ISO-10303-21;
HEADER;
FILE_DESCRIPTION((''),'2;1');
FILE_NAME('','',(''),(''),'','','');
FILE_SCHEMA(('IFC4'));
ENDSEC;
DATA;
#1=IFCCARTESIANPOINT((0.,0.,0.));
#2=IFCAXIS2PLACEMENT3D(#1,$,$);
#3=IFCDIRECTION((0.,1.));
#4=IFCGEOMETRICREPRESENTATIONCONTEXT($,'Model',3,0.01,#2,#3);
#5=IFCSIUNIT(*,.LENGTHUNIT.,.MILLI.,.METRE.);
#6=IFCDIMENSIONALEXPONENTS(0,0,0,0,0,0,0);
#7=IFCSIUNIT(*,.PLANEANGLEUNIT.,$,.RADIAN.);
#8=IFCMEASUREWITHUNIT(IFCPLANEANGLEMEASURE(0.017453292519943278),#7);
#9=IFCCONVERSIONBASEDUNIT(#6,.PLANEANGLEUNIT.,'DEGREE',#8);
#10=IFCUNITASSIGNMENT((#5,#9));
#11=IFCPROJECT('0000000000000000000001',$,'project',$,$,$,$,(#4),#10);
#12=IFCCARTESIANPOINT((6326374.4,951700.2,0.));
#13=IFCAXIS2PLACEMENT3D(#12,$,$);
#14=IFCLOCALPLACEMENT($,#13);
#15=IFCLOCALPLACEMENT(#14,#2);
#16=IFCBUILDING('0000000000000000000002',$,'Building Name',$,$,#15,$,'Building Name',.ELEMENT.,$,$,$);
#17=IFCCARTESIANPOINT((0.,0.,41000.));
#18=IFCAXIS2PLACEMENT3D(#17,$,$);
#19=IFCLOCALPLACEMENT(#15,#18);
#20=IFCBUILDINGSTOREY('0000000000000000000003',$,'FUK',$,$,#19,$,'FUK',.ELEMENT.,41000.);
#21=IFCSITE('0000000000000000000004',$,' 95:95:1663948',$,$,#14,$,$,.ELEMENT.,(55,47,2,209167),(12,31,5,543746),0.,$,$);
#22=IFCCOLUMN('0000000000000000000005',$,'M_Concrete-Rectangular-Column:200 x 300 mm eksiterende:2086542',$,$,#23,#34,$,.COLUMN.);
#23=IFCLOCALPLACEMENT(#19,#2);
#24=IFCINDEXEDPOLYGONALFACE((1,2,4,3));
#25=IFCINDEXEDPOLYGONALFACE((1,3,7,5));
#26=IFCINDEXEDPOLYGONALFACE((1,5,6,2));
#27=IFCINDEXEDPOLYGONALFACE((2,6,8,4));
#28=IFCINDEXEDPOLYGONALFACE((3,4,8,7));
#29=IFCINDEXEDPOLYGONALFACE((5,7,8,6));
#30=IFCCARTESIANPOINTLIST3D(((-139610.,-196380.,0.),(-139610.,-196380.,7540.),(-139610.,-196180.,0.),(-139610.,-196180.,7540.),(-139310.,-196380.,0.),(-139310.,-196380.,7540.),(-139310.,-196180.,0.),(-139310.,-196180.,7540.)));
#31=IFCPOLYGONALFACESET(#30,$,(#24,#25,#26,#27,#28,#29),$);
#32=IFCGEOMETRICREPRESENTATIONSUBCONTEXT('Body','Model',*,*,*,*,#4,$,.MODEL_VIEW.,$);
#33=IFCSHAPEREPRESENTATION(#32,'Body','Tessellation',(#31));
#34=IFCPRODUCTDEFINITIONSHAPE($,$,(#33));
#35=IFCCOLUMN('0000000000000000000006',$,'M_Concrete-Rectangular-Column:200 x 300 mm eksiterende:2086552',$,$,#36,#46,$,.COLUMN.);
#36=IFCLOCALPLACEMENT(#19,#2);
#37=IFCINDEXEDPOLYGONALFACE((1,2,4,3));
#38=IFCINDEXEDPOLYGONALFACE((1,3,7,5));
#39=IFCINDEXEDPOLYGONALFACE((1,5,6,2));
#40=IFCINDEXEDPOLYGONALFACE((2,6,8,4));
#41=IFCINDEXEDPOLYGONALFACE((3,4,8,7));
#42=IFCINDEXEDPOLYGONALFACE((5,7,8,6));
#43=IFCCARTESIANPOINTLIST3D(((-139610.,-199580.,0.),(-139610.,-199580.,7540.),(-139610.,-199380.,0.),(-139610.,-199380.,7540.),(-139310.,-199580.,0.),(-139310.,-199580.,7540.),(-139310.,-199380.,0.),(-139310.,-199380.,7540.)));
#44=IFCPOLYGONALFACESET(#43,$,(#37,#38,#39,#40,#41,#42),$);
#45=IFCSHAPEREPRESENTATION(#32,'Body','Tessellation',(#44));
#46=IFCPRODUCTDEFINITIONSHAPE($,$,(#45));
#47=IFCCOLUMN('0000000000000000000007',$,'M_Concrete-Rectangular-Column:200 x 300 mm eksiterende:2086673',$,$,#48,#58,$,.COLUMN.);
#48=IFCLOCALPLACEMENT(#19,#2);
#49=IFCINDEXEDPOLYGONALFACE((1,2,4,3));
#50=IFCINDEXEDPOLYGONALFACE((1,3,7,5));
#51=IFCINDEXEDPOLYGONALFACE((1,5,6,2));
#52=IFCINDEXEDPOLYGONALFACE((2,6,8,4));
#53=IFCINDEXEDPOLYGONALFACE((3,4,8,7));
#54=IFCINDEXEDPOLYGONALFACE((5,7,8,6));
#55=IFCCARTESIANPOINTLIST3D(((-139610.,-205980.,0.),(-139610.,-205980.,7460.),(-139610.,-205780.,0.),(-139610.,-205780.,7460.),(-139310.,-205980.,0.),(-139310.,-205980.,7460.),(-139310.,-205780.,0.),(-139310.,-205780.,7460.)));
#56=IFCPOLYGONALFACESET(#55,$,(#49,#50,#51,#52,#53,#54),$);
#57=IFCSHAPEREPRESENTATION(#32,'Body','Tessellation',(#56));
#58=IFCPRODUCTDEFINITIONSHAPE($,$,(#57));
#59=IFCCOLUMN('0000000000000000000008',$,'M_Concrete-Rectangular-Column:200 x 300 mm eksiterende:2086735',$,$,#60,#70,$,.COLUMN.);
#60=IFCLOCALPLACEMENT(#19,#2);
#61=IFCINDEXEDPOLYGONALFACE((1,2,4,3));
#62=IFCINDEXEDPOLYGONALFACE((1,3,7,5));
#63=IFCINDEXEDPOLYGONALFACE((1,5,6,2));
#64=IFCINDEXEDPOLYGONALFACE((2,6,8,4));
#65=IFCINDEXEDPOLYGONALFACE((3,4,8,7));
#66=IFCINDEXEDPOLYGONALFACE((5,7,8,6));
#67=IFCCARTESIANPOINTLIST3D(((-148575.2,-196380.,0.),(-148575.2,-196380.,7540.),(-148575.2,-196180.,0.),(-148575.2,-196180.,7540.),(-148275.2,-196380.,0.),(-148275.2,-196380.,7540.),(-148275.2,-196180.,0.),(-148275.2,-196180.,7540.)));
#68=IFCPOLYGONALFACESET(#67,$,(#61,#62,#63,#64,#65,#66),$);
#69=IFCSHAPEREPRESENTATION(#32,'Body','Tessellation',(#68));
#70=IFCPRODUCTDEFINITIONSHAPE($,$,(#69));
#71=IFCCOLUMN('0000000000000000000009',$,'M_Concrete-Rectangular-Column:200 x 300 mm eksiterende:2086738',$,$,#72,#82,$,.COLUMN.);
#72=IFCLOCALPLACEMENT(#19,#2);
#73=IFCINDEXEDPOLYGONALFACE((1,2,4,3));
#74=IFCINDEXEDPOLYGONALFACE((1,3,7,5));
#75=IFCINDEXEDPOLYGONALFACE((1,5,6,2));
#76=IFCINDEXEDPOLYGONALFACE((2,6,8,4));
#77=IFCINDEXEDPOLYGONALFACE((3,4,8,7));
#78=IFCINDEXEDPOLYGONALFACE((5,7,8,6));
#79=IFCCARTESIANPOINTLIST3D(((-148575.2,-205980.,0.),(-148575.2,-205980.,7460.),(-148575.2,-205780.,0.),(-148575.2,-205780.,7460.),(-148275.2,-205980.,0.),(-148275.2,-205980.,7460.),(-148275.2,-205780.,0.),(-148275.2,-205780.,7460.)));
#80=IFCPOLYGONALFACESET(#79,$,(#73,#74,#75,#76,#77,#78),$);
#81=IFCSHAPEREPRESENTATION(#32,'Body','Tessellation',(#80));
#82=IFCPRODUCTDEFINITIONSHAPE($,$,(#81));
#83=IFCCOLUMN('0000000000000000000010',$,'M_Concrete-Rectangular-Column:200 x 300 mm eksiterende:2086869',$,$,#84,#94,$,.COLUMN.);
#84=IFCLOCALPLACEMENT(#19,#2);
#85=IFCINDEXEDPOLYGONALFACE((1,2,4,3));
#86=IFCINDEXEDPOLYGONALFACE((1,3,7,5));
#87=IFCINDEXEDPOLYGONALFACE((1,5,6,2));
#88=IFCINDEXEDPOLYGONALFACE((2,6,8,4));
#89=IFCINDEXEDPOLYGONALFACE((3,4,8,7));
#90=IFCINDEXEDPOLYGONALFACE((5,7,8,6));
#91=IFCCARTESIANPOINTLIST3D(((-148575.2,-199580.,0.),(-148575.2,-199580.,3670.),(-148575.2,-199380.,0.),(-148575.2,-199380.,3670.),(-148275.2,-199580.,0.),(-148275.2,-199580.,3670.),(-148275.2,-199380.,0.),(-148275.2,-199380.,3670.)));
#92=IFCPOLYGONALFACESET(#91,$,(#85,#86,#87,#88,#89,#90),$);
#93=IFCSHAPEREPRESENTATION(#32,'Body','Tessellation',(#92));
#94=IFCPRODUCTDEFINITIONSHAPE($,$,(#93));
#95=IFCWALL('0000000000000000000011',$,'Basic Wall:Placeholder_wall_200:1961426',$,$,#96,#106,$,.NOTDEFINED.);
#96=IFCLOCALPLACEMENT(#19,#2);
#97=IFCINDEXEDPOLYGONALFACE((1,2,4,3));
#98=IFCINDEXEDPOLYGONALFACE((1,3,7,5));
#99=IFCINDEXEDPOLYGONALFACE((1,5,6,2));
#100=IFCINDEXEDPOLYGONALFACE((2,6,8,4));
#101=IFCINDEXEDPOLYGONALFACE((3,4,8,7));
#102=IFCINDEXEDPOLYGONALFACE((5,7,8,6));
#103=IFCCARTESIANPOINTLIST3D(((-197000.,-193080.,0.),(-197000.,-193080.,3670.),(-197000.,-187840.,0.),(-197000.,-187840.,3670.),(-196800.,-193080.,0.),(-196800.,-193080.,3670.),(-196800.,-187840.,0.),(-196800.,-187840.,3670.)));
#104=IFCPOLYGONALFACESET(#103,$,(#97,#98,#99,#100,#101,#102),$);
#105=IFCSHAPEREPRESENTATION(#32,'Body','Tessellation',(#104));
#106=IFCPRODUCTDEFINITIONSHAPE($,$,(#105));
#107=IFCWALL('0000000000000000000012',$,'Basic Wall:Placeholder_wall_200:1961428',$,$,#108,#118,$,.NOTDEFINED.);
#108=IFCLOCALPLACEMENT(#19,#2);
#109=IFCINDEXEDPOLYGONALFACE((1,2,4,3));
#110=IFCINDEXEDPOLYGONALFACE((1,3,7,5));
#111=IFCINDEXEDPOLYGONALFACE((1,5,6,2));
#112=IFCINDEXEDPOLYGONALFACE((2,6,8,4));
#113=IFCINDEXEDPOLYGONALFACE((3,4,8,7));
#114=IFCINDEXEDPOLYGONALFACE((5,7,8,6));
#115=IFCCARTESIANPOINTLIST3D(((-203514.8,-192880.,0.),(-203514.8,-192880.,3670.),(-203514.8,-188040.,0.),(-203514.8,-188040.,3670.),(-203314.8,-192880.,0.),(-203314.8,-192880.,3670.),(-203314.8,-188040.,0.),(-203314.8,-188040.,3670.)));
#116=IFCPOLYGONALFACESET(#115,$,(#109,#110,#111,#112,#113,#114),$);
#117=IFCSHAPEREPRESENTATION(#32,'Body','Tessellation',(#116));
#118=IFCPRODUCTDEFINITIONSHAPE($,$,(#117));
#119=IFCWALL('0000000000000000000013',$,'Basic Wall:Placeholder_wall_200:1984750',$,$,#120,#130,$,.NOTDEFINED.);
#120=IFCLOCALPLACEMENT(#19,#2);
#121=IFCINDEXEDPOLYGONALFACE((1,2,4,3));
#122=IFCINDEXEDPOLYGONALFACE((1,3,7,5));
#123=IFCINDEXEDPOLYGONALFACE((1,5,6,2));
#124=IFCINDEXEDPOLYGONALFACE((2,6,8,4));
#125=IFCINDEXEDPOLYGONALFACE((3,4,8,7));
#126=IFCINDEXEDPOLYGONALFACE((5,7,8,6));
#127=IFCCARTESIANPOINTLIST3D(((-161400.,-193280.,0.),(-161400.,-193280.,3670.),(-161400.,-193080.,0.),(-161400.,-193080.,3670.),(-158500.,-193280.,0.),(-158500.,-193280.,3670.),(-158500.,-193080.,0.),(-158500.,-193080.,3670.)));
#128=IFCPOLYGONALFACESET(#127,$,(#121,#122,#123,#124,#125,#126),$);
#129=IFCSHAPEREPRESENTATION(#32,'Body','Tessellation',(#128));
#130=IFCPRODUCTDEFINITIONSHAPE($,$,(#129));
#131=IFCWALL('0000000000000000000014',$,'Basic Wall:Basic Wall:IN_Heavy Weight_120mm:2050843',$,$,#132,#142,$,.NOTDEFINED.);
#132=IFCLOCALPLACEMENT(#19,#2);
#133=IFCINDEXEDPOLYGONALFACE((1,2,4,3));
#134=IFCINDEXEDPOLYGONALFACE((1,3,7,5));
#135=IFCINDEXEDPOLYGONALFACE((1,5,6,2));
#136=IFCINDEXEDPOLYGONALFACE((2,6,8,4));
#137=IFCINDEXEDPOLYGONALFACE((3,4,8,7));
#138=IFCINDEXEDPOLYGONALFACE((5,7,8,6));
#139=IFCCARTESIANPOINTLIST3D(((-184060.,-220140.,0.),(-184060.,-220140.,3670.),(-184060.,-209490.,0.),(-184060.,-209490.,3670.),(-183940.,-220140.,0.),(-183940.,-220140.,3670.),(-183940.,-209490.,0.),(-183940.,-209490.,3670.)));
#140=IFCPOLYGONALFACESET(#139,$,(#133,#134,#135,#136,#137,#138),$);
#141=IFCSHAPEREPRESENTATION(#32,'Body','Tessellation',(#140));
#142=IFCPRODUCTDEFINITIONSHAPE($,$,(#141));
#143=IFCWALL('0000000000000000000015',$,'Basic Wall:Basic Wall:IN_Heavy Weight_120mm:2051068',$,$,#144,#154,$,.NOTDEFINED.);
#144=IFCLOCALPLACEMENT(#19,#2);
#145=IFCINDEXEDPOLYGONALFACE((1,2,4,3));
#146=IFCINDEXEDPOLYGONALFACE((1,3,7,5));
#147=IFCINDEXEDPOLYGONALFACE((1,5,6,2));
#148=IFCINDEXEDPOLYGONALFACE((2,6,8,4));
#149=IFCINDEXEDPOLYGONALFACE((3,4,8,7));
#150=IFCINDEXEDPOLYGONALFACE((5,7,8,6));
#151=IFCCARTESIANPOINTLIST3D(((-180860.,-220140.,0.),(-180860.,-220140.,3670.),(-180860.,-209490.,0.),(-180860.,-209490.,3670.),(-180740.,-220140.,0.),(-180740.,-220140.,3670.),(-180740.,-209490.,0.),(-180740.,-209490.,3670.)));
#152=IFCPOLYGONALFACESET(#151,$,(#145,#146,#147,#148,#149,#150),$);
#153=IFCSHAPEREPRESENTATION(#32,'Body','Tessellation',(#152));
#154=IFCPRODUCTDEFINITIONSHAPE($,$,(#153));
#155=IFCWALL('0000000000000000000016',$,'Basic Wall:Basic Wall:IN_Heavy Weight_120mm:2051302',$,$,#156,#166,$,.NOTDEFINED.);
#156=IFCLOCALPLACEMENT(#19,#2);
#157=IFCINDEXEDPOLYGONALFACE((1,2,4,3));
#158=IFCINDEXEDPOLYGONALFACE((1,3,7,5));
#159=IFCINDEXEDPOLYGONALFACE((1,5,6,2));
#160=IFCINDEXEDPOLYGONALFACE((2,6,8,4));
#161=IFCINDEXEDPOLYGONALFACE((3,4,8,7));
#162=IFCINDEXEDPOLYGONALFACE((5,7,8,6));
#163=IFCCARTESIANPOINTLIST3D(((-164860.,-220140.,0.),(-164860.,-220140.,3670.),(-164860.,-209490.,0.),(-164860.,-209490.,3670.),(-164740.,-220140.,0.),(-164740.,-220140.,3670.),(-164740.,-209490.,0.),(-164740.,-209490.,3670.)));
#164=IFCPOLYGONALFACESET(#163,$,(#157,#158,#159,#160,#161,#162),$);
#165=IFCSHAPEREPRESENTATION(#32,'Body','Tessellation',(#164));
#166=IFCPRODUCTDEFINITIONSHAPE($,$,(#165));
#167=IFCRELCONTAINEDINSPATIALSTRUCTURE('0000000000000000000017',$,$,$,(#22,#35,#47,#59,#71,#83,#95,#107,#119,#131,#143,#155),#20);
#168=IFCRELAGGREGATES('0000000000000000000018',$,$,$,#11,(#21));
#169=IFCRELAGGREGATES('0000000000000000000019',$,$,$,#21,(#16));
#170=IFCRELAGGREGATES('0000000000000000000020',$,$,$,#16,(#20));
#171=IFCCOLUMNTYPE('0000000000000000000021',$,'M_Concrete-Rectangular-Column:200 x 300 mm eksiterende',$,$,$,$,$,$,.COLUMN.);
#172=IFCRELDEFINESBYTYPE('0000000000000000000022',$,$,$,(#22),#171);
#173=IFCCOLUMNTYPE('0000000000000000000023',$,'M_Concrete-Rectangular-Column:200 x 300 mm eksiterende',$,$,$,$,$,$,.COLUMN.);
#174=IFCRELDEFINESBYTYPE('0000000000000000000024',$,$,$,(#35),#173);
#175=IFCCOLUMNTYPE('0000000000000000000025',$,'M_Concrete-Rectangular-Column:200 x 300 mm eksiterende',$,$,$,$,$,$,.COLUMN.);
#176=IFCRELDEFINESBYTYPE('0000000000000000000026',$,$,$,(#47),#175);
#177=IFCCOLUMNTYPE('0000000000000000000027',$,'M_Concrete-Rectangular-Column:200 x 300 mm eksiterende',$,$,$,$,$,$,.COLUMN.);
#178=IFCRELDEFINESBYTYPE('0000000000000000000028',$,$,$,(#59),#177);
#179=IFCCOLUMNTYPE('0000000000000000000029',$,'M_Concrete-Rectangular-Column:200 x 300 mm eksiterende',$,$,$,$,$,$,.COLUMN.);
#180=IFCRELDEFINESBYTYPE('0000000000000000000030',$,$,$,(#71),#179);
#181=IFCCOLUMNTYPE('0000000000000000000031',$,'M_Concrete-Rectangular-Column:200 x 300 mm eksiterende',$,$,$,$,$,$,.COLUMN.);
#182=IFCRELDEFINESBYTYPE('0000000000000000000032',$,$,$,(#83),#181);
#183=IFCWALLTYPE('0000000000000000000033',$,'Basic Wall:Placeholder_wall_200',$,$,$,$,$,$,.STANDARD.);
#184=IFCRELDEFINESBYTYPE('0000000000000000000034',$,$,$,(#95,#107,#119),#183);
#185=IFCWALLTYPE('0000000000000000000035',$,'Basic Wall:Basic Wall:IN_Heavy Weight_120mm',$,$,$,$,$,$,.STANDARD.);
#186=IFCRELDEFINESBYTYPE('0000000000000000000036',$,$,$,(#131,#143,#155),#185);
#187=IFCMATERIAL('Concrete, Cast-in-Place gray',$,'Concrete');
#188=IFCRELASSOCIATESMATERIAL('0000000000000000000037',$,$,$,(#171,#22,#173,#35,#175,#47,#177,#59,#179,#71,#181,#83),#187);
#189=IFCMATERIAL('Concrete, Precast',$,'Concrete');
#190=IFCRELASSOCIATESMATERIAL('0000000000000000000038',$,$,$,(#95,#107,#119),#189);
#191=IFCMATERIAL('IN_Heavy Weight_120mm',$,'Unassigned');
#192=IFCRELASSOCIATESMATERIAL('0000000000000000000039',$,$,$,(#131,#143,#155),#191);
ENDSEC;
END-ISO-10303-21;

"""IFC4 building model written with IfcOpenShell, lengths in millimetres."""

from ifc_helpers import new_model, entity, si_unit, converted_unit, direction, frame, origin, place, context, subcontext, project, spatial, indexed_curve, outline, extrude, source, transform, mapped, material, type_object, type_shapes, element, save


model = new_model("IFC4")

# Units and contexts
model_context = context("Model", 3, precision=0.01, world=origin(), true_north=direction((0.0, 1.0)))
body_context = subcontext(model_context, "Body", "Model", "MODEL_VIEW")
ifc_project = project(units=[si_unit("LENGTHUNIT", "METRE", prefix="MILLI"), converted_unit("PLANEANGLEUNIT", "DEGREE", entity("IfcPlaneAngleMeasure", 0.017453292519943278), si_unit("PLANEANGLEUNIT", "RADIAN"), dimensions=[0, 0, 0, 0, 0, 0, 0])], contexts=[model_context])

# Site, building, storey
site_placement = place(None, frame((6326374.4, 951700.2, 0.0)))
site = spatial("IfcSite", under=ifc_project, at=site_placement, Name=" 95:95:1663948", CompositionType="ELEMENT", RefLatitude=(55, 47, 2, 209167), RefLongitude=(12, 31, 5, 543746), RefElevation=0.0)
building_placement = place(site_placement, origin())
building = spatial("IfcBuilding", under=site, at=building_placement, Name="Building Name", LongName="Building Name", CompositionType="ELEMENT")
storey_placement = place(building_placement, frame((0.0, 0.0, 41000.0)))
storey = spatial("IfcBuildingStorey", under=building, at=storey_placement, Name="FUK", LongName="FUK", CompositionType="ELEMENT", Elevation=41000.0)

# Columns
ifc_material_1 = material(Name="Concrete, Cast-in-Place gray", Category="Concrete")
column_type_1 = type_object("IfcColumnType", Name="M_Concrete-Rectangular-Column:200 x 300 mm eksiterende", PredefinedType="COLUMN", material=ifc_material_1)
shared_shape_1 = source(origin(), body_context, "Body", "SweptSolid", [
    extrude(outline(indexed_curve([(-3770.0, -100.0), (3770.0, -100.0), (3770.0, 100.0), (-3770.0, 100.0), (-3770.0, -100.0)], self_intersect=False)), frame((-139610.0, -196280.0, 44770.0), z_axis=(1.0, 0.0, 0.0), x_axis=(0.0, 0.0, 1.0)), (0.0, 0.0, 1.0), 300.0),
])
type_shapes(column_type_1, [shared_shape_1])
column_1_placement = place(storey_placement, frame((0.0, 0.0, -41000.0)))
element("IfcColumn", 1, at=column_1_placement, inside=storey, type_object=column_type_1, material=ifc_material_1, Name="M_Concrete-Rectangular-Column:200 x 300 mm eksiterende:2086542", PredefinedType="COLUMN", context=body_context, shape_type="MappedRepresentation", body=[
    mapped(shared_shape_1, transform((0.0, 0.0, 0.0), scale=1.0)),
])
column_type_2 = type_object("IfcColumnType", Name="M_Concrete-Rectangular-Column:200 x 300 mm eksiterende", PredefinedType="COLUMN", material=ifc_material_1)
shared_shape_2 = source(origin(), body_context, "Body", "SweptSolid", [
    extrude(outline(indexed_curve([(-3770.0, -100.0), (3770.0, -100.0), (3770.0, 100.0), (-3770.0, 100.0), (-3770.0, -100.0)], self_intersect=False)), frame((-139610.0, -199480.0, 44770.0), z_axis=(1.0, 0.0, 0.0), x_axis=(0.0, 0.0, 1.0)), (0.0, 0.0, 1.0), 300.0),
])
type_shapes(column_type_2, [shared_shape_2])
column_2_placement = place(storey_placement, frame((0.0, 0.0, -41000.0)))
element("IfcColumn", 2, at=column_2_placement, inside=storey, type_object=column_type_2, material=ifc_material_1, Name="M_Concrete-Rectangular-Column:200 x 300 mm eksiterende:2086552", PredefinedType="COLUMN", context=body_context, shape_type="MappedRepresentation", body=[
    mapped(shared_shape_2, transform((0.0, 0.0, 0.0), scale=1.0)),
])
column_type_3 = type_object("IfcColumnType", Name="M_Concrete-Rectangular-Column:200 x 300 mm eksiterende", PredefinedType="COLUMN", material=ifc_material_1)
shared_shape_3 = source(origin(), body_context, "Body", "SweptSolid", [
    extrude(outline(indexed_curve([(-150.0, -100.0), (150.0, -100.0), (150.0, 100.0), (-150.0, 100.0), (-150.0, -100.0)], self_intersect=False)), frame((-139460.0, -205880.0, 41000.0), z_axis=(0.0, 0.0, 1.0), x_axis=(-1.0, 0.0, 0.0)), (0.0, 0.0, 1.0), 7460.0),
])
type_shapes(column_type_3, [shared_shape_3])
column_3_placement = place(storey_placement, frame((0.0, 0.0, -41000.0)))
element("IfcColumn", 3, at=column_3_placement, inside=storey, type_object=column_type_3, material=ifc_material_1, Name="M_Concrete-Rectangular-Column:200 x 300 mm eksiterende:2086673", PredefinedType="COLUMN", context=body_context, shape_type="MappedRepresentation", body=[
    mapped(shared_shape_3, transform((0.0, 0.0, 0.0), scale=1.0)),
])
column_type_4 = type_object("IfcColumnType", Name="M_Concrete-Rectangular-Column:200 x 300 mm eksiterende", PredefinedType="COLUMN", material=ifc_material_1)
shared_shape_4 = source(origin(), body_context, "Body", "SweptSolid", [
    extrude(outline(indexed_curve([(-3770.0, -100.0), (3770.0, -100.0), (3770.0, 100.0), (-3770.0, 100.0), (-3770.0, -100.0)], self_intersect=False)), frame((-148575.2, -196280.0, 44770.0), z_axis=(1.0, 0.0, 0.0), x_axis=(0.0, 0.0, 1.0)), (0.0, 0.0, 1.0), 300.0),
])
type_shapes(column_type_4, [shared_shape_4])
column_4_placement = place(storey_placement, frame((0.0, 0.0, -41000.0)))
element("IfcColumn", 4, at=column_4_placement, inside=storey, type_object=column_type_4, material=ifc_material_1, Name="M_Concrete-Rectangular-Column:200 x 300 mm eksiterende:2086735", PredefinedType="COLUMN", context=body_context, shape_type="MappedRepresentation", body=[
    mapped(shared_shape_4, transform((0.0, 0.0, 0.0), scale=1.0)),
])
column_type_5 = type_object("IfcColumnType", Name="M_Concrete-Rectangular-Column:200 x 300 mm eksiterende", PredefinedType="COLUMN", material=ifc_material_1)
shared_shape_5 = source(origin(), body_context, "Body", "SweptSolid", [
    extrude(outline(indexed_curve([(-150.0, -100.0), (150.0, -100.0), (150.0, 100.0), (-150.0, 100.0), (-150.0, -100.0)], self_intersect=False)), frame((-148425.2, -205880.0, 41000.0), z_axis=(0.0, 0.0, 1.0), x_axis=(-1.0, 0.0, 0.0)), (0.0, 0.0, 1.0), 7460.0),
])
type_shapes(column_type_5, [shared_shape_5])
column_5_placement = place(storey_placement, frame((0.0, 0.0, -41000.0)))
element("IfcColumn", 5, at=column_5_placement, inside=storey, type_object=column_type_5, material=ifc_material_1, Name="M_Concrete-Rectangular-Column:200 x 300 mm eksiterende:2086738", PredefinedType="COLUMN", context=body_context, shape_type="MappedRepresentation", body=[
    mapped(shared_shape_5, transform((0.0, 0.0, 0.0), scale=1.0)),
])
column_type_6 = type_object("IfcColumnType", Name="M_Concrete-Rectangular-Column:200 x 300 mm eksiterende", PredefinedType="COLUMN", material=ifc_material_1)
shared_shape_6 = source(origin(), body_context, "Body", "SweptSolid", [
    extrude(outline(indexed_curve([(-150.0, -100.0), (150.0, -100.0), (150.0, 100.0), (-150.0, 100.0), (-150.0, -100.0)], self_intersect=False)), frame((-148425.2, -199480.0, 41000.0), z_axis=(0.0, 0.0, 1.0), x_axis=(-1.0, 0.0, 0.0)), (0.0, 0.0, 1.0), 3670.0),
])
type_shapes(column_type_6, [shared_shape_6])
column_6_placement = place(storey_placement, frame((0.0, 0.0, -41000.0)))
element("IfcColumn", 6, at=column_6_placement, inside=storey, type_object=column_type_6, material=ifc_material_1, Name="M_Concrete-Rectangular-Column:200 x 300 mm eksiterende:2086869", PredefinedType="COLUMN", context=body_context, shape_type="MappedRepresentation", body=[
    mapped(shared_shape_6, transform((0.0, 0.0, 0.0), scale=1.0)),
])

# Walls
ifc_material_2 = material(Name="Concrete, Precast", Category="Concrete")
wall_type_1 = type_object("IfcWallType", Name="Basic Wall:Placeholder_wall_200", PredefinedType="STANDARD")
wall_1_placement = place(storey_placement, frame((-196900.0, -193080.0, 0.0), z_axis=(0.0, 0.0, 1.0), x_axis=(0.0, 1.0, 0.0)))
element("IfcWall", 7, at=wall_1_placement, inside=storey, type_object=wall_type_1, material=ifc_material_2, Name="Basic Wall:Placeholder_wall_200:1961426", PredefinedType="NOTDEFINED", context=body_context, shape_type="SweptSolid", body=[
    extrude(outline(indexed_curve([(5240.0, 100.0), (0.0, 100.0), (0.0, -100.0), (5240.0, -100.0), (5240.0, 100.0)], self_intersect=False)), origin(), (0.0, 0.0, 1.0), 3670.0),
])
wall_2_placement = place(storey_placement, frame((-203414.8, -188040.0, 0.0), z_axis=(0.0, 0.0, 1.0), x_axis=(0.0, -1.0, 0.0)))
element("IfcWall", 8, at=wall_2_placement, inside=storey, type_object=wall_type_1, material=ifc_material_2, Name="Basic Wall:Placeholder_wall_200:1961428", PredefinedType="NOTDEFINED", context=body_context, shape_type="SweptSolid", body=[
    extrude(outline(indexed_curve([(4840.0, 100.0), (0.0, 100.0), (0.0, -100.0), (4840.0, -100.0), (4840.0, 100.0)], self_intersect=False)), origin(), (0.0, 0.0, 1.0), 3670.0),
])
wall_3_placement = place(storey_placement, frame((-161400.0, -193180.0, 0.0)))
element("IfcWall", 9, at=wall_3_placement, inside=storey, type_object=wall_type_1, material=ifc_material_2, Name="Basic Wall:Placeholder_wall_200:1984750", PredefinedType="NOTDEFINED", context=body_context, shape_type="SweptSolid", body=[
    extrude(outline(indexed_curve([(2900.0, 100.0), (0.0, 100.0), (0.0, -100.0), (2900.0, -100.0), (2900.0, 100.0)], self_intersect=False)), origin(), (0.0, 0.0, 1.0), 3670.0),
])
ifc_material_3 = material(Name="IN_Heavy Weight_120mm", Category="Unassigned")
wall_type_2 = type_object("IfcWallType", Name="Basic Wall:Basic Wall:IN_Heavy Weight_120mm", PredefinedType="STANDARD")
wall_4_placement = place(storey_placement, frame((-184000.0, -209490.0, 0.0), z_axis=(0.0, 0.0, 1.0), x_axis=(0.0, -1.0, 0.0)))
element("IfcWall", 10, at=wall_4_placement, inside=storey, type_object=wall_type_2, material=ifc_material_3, Name="Basic Wall:Basic Wall:IN_Heavy Weight_120mm:2050843", PredefinedType="NOTDEFINED", context=body_context, shape_type="SweptSolid", body=[
    extrude(outline(indexed_curve([(10650.0, 60.0), (0.0, 60.0), (0.0, -60.0), (10650.0, -60.0), (10650.0, 60.0)], self_intersect=False)), origin(), (0.0, 0.0, 1.0), 3670.0),
])
wall_5_placement = place(storey_placement, frame((-180800.0, -220140.0, 0.0), z_axis=(0.0, 0.0, 1.0), x_axis=(0.0, 1.0, 0.0)))
element("IfcWall", 11, at=wall_5_placement, inside=storey, type_object=wall_type_2, material=ifc_material_3, Name="Basic Wall:Basic Wall:IN_Heavy Weight_120mm:2051068", PredefinedType="NOTDEFINED", context=body_context, shape_type="SweptSolid", body=[
    extrude(outline(indexed_curve([(10650.0, 60.0), (0.0, 60.0), (0.0, -60.0), (10650.0, -60.0), (10650.0, 60.0)], self_intersect=False)), origin(), (0.0, 0.0, 1.0), 3670.0),
])
wall_6_placement = place(storey_placement, frame((-164800.0, -220140.0, 0.0), z_axis=(0.0, 0.0, 1.0), x_axis=(0.0, 1.0, 0.0)))
element("IfcWall", 12, at=wall_6_placement, inside=storey, type_object=wall_type_2, material=ifc_material_3, Name="Basic Wall:Basic Wall:IN_Heavy Weight_120mm:2051302", PredefinedType="NOTDEFINED", context=body_context, shape_type="SweptSolid", body=[
    extrude(outline(indexed_curve([(10650.0, 60.0), (0.0, 60.0), (0.0, -60.0), (10650.0, -60.0), (10650.0, 60.0)], self_intersect=False)), origin(), (0.0, 0.0, 1.0), 3670.0),
])

save(model, "model.ifc")
